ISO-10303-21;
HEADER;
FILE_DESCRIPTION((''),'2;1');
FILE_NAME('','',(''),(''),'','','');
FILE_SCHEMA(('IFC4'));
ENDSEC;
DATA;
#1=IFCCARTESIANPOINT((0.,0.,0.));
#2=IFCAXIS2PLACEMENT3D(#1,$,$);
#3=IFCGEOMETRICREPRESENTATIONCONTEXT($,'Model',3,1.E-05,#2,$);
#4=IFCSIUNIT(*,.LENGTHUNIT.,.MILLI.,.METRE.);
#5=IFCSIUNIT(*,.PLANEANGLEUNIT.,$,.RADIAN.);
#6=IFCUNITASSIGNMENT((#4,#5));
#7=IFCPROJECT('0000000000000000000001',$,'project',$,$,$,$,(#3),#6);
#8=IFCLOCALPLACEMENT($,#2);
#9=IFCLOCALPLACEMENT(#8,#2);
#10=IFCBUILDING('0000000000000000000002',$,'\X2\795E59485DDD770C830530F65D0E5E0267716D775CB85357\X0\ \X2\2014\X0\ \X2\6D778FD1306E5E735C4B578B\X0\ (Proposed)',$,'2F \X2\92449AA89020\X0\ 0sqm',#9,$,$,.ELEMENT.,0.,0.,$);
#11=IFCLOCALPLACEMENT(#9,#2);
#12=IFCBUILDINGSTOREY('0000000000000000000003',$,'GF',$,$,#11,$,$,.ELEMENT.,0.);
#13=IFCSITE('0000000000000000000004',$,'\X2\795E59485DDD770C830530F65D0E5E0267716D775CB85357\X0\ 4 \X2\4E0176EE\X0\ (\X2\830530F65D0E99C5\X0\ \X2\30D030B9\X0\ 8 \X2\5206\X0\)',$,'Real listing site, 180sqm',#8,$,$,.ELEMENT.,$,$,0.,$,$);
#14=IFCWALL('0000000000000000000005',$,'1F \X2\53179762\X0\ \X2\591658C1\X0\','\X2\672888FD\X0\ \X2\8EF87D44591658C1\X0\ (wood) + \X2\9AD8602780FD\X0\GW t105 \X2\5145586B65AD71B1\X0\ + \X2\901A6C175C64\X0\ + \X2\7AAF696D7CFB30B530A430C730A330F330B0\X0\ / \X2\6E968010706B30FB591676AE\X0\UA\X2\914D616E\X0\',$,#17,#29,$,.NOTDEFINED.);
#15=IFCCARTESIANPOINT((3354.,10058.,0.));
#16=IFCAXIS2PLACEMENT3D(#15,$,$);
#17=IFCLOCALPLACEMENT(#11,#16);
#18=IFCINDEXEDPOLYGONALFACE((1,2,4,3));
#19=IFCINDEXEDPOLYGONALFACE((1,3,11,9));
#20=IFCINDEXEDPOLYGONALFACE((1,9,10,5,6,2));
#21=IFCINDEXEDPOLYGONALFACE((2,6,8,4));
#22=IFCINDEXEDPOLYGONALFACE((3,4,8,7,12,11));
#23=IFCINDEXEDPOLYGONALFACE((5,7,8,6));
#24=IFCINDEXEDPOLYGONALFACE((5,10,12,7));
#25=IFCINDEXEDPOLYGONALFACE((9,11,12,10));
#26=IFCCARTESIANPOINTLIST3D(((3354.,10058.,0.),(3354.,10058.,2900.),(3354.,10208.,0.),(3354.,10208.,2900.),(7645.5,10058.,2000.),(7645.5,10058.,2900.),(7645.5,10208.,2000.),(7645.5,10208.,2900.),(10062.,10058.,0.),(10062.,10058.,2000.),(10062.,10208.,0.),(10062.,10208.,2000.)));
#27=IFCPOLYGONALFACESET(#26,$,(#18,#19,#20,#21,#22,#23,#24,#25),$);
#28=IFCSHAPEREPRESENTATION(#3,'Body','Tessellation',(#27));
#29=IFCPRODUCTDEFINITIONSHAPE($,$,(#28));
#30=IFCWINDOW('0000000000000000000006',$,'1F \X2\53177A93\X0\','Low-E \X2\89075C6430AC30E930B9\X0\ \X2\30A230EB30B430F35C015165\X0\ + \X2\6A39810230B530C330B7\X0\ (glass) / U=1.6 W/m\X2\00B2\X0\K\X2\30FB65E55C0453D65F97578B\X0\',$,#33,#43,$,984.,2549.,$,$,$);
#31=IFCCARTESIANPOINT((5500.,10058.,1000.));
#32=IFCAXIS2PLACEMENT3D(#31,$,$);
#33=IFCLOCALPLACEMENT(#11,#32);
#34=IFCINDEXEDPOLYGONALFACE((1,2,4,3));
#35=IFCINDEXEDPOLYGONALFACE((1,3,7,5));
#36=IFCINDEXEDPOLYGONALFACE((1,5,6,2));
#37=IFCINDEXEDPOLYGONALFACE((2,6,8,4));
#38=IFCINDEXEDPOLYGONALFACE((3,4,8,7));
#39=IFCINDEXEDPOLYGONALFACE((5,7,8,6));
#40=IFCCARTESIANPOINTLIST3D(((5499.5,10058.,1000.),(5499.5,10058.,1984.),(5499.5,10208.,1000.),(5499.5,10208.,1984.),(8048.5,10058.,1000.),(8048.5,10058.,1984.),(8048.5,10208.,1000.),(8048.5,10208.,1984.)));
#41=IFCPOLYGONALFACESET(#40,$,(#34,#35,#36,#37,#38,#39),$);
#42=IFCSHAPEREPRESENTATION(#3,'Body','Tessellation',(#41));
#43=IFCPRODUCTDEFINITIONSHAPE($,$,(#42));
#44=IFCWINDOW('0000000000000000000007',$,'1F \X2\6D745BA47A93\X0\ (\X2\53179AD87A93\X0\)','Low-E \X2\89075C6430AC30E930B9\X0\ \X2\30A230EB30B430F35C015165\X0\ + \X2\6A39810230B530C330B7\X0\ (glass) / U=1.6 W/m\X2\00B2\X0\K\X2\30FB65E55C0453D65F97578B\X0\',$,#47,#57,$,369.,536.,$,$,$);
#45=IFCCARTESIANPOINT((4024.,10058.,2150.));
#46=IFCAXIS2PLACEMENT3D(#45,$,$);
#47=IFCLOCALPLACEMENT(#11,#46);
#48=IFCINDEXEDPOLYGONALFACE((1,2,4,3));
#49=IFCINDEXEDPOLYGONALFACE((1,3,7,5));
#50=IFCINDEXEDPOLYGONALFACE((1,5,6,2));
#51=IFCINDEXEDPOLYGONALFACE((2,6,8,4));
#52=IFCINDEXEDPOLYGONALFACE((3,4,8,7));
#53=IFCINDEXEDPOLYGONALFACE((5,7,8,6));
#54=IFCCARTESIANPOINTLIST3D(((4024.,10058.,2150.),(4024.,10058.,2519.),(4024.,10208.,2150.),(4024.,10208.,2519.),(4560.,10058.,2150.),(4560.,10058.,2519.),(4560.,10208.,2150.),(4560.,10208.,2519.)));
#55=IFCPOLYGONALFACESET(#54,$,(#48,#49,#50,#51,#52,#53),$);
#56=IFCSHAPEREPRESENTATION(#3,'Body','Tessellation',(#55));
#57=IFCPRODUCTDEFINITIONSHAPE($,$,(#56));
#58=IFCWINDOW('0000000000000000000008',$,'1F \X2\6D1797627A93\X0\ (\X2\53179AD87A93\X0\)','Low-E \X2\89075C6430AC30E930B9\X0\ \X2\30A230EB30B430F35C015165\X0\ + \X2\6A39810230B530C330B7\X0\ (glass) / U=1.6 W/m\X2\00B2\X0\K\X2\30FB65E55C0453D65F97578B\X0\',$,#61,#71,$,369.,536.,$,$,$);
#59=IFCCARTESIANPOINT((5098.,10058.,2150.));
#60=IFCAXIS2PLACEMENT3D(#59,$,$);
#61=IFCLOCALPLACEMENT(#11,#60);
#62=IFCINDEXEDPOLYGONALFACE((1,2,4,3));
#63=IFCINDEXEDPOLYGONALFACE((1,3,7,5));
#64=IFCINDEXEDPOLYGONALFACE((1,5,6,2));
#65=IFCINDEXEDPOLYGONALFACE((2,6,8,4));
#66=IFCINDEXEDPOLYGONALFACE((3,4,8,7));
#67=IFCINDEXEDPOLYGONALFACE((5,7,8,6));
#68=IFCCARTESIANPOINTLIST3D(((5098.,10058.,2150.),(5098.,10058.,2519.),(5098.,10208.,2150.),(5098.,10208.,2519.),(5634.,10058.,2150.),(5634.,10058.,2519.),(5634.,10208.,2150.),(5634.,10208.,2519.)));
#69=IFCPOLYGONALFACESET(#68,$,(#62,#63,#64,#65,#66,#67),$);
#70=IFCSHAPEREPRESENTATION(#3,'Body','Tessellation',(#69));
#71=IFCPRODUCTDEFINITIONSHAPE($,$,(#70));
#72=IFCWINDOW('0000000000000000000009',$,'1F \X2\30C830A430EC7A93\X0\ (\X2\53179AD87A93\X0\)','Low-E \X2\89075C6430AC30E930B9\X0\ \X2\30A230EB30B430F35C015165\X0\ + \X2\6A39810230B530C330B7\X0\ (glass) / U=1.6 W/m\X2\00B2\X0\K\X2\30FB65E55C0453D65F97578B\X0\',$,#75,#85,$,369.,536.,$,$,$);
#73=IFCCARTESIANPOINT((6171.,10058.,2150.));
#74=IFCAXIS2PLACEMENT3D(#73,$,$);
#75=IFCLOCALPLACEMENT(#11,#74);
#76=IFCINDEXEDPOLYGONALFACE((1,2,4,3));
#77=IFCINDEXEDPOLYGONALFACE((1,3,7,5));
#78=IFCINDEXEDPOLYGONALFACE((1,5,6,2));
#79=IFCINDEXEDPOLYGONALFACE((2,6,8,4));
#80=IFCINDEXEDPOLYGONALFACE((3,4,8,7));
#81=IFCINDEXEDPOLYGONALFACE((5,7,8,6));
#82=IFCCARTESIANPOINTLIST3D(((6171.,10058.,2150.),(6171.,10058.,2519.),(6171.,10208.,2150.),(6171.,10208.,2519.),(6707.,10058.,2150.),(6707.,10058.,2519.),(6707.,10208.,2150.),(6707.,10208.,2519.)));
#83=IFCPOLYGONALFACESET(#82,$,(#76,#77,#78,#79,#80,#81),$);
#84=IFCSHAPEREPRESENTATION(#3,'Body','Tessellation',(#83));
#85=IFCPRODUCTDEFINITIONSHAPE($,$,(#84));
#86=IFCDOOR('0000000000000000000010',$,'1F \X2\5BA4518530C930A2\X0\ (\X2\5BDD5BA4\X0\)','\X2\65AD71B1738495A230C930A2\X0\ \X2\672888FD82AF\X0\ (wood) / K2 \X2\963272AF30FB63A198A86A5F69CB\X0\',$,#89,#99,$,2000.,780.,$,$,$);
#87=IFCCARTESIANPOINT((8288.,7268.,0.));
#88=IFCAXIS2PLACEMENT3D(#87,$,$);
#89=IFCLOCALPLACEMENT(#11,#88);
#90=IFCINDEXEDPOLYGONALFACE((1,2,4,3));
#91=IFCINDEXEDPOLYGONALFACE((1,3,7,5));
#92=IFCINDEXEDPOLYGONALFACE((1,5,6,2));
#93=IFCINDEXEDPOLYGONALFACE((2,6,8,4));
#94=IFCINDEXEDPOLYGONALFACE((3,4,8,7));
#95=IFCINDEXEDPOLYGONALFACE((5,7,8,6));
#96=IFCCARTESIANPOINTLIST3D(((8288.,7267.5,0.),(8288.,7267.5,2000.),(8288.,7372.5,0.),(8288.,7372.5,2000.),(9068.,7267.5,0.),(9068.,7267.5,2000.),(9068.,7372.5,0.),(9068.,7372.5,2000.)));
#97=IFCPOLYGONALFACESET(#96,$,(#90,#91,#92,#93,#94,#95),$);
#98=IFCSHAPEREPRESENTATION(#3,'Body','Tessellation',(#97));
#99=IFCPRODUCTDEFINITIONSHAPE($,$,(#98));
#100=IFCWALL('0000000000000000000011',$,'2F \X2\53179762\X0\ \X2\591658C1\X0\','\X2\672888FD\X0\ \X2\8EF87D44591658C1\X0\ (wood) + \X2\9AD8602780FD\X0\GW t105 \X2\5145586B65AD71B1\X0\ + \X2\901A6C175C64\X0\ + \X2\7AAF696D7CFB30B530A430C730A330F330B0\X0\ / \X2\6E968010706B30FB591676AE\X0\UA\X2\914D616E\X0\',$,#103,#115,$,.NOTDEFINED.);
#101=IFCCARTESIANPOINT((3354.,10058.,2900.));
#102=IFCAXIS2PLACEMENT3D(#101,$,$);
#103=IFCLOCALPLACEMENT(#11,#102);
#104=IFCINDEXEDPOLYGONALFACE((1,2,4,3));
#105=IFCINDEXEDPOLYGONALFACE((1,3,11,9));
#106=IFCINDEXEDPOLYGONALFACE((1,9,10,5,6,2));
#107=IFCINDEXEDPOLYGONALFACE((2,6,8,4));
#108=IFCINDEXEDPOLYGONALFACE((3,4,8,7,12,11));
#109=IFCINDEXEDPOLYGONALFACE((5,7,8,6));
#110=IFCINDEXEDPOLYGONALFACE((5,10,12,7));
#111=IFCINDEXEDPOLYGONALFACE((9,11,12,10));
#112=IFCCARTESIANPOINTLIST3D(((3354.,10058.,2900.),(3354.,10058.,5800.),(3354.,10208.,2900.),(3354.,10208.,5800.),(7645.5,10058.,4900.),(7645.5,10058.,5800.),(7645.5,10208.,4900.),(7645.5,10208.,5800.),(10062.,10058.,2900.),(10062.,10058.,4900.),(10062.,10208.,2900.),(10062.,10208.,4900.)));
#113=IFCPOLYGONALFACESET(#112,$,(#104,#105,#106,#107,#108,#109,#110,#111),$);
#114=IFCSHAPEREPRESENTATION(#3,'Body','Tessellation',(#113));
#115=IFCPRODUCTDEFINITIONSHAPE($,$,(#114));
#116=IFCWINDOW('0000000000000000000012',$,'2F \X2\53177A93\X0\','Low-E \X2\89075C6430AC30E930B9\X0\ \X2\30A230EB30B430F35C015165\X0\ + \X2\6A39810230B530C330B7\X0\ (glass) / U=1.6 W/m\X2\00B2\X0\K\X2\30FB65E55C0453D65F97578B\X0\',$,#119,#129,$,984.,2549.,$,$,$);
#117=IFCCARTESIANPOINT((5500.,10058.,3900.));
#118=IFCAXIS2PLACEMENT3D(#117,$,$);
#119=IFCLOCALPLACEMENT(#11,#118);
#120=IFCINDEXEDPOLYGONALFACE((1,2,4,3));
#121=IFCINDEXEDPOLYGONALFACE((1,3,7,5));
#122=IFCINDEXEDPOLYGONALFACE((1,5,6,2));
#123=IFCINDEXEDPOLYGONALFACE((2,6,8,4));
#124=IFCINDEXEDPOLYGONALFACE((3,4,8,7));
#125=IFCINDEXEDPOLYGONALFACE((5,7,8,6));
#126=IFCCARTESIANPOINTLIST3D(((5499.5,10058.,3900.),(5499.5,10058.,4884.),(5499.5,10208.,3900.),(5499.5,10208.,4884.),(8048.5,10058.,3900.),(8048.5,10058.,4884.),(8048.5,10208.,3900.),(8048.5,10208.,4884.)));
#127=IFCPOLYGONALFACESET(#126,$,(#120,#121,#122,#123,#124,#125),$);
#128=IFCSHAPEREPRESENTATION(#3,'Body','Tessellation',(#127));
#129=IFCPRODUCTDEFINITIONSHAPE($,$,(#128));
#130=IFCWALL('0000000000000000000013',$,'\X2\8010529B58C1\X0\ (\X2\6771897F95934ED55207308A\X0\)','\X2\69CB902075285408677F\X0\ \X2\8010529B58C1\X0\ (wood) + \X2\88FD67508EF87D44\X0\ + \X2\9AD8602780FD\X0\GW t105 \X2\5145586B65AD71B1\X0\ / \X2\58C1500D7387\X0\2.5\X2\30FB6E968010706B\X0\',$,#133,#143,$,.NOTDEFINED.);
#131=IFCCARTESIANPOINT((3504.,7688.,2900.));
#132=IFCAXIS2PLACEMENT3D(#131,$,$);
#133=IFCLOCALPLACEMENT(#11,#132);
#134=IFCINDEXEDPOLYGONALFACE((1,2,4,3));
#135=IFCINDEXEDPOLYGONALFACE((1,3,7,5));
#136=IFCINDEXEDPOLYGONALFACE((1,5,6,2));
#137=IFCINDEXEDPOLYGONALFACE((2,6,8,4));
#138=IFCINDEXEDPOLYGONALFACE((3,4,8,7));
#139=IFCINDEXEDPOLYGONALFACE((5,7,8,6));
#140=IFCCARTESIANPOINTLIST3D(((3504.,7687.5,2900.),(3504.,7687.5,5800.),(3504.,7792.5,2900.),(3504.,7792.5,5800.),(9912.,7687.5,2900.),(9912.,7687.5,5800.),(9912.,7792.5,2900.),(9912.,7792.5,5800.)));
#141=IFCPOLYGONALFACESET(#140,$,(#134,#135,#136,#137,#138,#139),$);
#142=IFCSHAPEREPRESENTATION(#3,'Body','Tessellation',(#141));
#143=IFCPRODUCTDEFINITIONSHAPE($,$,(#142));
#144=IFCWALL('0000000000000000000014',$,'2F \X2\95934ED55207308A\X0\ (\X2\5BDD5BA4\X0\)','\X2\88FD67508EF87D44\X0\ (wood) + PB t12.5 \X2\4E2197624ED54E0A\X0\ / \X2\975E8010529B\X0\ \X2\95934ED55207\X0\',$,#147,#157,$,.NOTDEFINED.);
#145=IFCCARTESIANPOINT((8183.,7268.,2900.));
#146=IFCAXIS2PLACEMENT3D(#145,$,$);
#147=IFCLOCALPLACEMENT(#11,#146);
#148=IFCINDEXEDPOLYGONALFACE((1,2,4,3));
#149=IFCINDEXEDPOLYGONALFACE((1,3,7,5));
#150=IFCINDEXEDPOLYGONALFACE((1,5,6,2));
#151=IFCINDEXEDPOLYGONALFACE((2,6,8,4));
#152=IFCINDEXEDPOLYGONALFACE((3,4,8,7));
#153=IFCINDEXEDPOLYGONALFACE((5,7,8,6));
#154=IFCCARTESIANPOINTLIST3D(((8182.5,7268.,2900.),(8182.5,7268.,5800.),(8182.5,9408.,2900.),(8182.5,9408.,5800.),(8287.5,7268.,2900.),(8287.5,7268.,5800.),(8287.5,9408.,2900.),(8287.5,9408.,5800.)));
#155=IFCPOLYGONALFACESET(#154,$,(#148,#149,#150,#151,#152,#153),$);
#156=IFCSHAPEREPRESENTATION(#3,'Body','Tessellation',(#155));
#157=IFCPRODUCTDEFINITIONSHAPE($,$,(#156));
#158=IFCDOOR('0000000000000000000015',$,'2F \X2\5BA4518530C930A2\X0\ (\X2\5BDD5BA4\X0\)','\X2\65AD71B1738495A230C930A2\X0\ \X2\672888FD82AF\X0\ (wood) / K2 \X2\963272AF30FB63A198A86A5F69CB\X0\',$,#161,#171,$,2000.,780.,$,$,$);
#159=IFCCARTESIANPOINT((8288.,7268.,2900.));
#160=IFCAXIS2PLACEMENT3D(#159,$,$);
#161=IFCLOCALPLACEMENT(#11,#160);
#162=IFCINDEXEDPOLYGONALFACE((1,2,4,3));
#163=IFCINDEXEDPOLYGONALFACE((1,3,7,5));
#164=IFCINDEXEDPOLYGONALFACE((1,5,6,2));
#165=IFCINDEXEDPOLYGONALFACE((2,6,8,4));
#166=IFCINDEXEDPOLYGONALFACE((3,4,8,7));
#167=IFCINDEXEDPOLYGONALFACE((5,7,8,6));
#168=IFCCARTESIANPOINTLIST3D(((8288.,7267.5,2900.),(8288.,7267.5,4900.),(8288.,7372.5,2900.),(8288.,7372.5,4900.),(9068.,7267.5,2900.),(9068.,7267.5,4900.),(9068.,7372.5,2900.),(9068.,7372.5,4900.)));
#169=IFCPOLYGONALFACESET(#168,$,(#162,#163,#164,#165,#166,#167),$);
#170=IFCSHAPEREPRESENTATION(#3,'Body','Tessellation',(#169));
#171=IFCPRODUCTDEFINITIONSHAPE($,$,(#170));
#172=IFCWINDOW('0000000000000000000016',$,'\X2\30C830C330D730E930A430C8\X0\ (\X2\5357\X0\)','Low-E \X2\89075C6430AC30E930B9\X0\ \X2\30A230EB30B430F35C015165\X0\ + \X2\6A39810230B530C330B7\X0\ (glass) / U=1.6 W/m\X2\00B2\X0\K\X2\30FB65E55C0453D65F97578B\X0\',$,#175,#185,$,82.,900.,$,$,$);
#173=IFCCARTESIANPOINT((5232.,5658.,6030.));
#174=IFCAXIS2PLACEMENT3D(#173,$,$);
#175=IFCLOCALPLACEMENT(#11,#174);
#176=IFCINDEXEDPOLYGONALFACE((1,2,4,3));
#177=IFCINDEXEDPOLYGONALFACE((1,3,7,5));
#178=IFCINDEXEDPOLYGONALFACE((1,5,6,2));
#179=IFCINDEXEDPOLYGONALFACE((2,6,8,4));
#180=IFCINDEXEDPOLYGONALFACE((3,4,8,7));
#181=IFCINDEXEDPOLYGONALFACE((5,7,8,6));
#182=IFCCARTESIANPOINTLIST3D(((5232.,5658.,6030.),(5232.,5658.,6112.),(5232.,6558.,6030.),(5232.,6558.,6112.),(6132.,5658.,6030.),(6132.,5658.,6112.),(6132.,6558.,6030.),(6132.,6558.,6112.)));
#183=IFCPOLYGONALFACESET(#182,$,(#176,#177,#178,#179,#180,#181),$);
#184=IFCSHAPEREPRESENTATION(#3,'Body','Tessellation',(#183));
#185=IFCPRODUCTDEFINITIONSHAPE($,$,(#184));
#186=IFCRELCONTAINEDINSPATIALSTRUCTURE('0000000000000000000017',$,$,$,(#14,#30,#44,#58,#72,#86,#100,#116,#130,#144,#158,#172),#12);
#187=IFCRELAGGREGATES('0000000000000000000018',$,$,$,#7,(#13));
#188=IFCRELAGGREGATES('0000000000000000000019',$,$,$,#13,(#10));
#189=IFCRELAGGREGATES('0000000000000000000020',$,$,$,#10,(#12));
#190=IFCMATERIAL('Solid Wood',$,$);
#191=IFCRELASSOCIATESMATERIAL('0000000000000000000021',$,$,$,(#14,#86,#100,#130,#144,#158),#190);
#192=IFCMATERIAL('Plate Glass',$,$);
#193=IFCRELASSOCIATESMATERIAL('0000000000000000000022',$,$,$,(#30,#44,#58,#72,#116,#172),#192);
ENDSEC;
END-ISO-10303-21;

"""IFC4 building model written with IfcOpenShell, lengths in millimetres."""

from ifc_helpers import new_model, si_unit, frame, frame_2d, origin, place, context, project, spatial, rectangle, extrude, material, element, fill, save


model = new_model("IFC4")

# Units and contexts
model_context = context("Model", 3, precision=1e-05, world=origin())
ifc_project = project(units=[si_unit("LENGTHUNIT", "METRE", prefix="MILLI"), si_unit("PLANEANGLEUNIT", "RADIAN")], contexts=[model_context])

# Site, building, storey
site_placement = place(None, origin())
site = spatial("IfcSite", under=ifc_project, at=site_placement, Name="神奈川県茅ヶ崎市東海岸南 4 丁目 (茅ヶ崎駅 バス 8 分)", ObjectType="Real listing site, 180sqm", CompositionType="ELEMENT", RefElevation=0.0)
building_placement = place(site_placement, origin())
building = spatial("IfcBuilding", under=site, at=building_placement, Name="神奈川県茅ヶ崎市東海岸南 — 海近の平屋型 (Proposed)", ObjectType="2F 鉄骨造 0sqm", CompositionType="ELEMENT", ElevationOfRefHeight=0.0, ElevationOfTerrain=0.0)
storey_placement = place(building_placement, origin())
storey = spatial("IfcBuildingStorey", under=building, at=storey_placement, Name="GF", CompositionType="ELEMENT", Elevation=0.0)

# Wall, openings, windows
ifc_material_1 = material(Name="Solid Wood")
wall_1_placement = place(storey_placement, frame((3354.0, 10058.0, 0.0)))
wall_1 = element("IfcWall", 1, at=wall_1_placement, inside=storey, material=ifc_material_1, Name="1F 北面 外壁", Description="木製 軸組外壁 (wood) + 高性能GW t105 充填断熱 + 通気層 + 窯業系サイディング / 準耐火・外皮UA配慮", PredefinedType="NOTDEFINED", context=model_context, shape_type="SweptSolid", body=[
    extrude(rectangle(XDim=6708.0, YDim=150.0, at=frame_2d((3354.0, 75.0))), frame((3354.0, 10058.0, 0.0)), (0.0, 0.0, 1.0), 2900.0),
])
opening_1_placement = place(storey_placement, frame((5500.0, 10058.0, 1000.0)))
opening_1 = element("IfcOpeningElement", 2, at=opening_1_placement, cuts=wall_1, PredefinedType="NOTDEFINED", context=model_context, shape_type="SweptSolid", body=[
    extrude(rectangle(XDim=2549.0, YDim=150.0, at=frame_2d((1274.0, 75.0))), frame((5500.0, 10058.0, 1000.0)), (0.0, 0.0, 1.0), 984.0),
])
opening_2_placement = place(storey_placement, frame((4024.0, 10058.0, 2150.0)))
opening_2 = element("IfcOpeningElement", 3, at=opening_2_placement, cuts=wall_1, PredefinedType="NOTDEFINED", context=model_context, shape_type="SweptSolid", body=[
    extrude(rectangle(XDim=536.0, YDim=150.0, at=frame_2d((268.0, 75.0))), frame((4024.0, 10058.0, 2150.0)), (0.0, 0.0, 1.0), 369.0),
])
opening_3_placement = place(storey_placement, frame((5098.0, 10058.0, 2150.0)))
opening_3 = element("IfcOpeningElement", 4, at=opening_3_placement, cuts=wall_1, PredefinedType="NOTDEFINED", context=model_context, shape_type="SweptSolid", body=[
    extrude(rectangle(XDim=536.0, YDim=150.0, at=frame_2d((268.0, 75.0))), frame((5098.0, 10058.0, 2150.0)), (0.0, 0.0, 1.0), 369.0),
])
opening_4_placement = place(storey_placement, frame((6171.0, 10058.0, 2150.0)))
opening_4 = element("IfcOpeningElement", 5, at=opening_4_placement, cuts=wall_1, PredefinedType="NOTDEFINED", context=model_context, shape_type="SweptSolid", body=[
    extrude(rectangle(XDim=536.0, YDim=150.0, at=frame_2d((268.0, 75.0))), frame((6171.0, 10058.0, 2150.0)), (0.0, 0.0, 1.0), 369.0),
])
ifc_material_2 = material(Name="Plate Glass")
window_1_placement = place(storey_placement, frame((5500.0, 10058.0, 1000.0)))
window_1 = element("IfcWindow", 6, at=window_1_placement, inside=storey, material=ifc_material_2, Name="1F 北窓", Description="Low-E 複層ガラス アルゴン封入 + 樹脂サッシ (glass) / U=1.6 W/m²K・日射取得型", OverallHeight=984.0, OverallWidth=2549.0, context=model_context, shape_type="SweptSolid", body=[
    extrude(rectangle(XDim=2549.0, YDim=150.0, at=frame_2d((1274.0, 75.0))), frame((5500.0, 10058.0, 1000.0)), (0.0, 0.0, 1.0), 984.0),
])
fill(opening_1, window_1)
window_2_placement = place(storey_placement, frame((4024.0, 10058.0, 2150.0)))
window_2 = element("IfcWindow", 7, at=window_2_placement, inside=storey, material=ifc_material_2, Name="1F 浴室窓 (北高窓)", Description="Low-E 複層ガラス アルゴン封入 + 樹脂サッシ (glass) / U=1.6 W/m²K・日射取得型", OverallHeight=369.0, OverallWidth=536.0, context=model_context, shape_type="SweptSolid", body=[
    extrude(rectangle(XDim=536.0, YDim=150.0, at=frame_2d((268.0, 75.0))), frame((4024.0, 10058.0, 2150.0)), (0.0, 0.0, 1.0), 369.0),
])
fill(opening_2, window_2)
window_3_placement = place(storey_placement, frame((5098.0, 10058.0, 2150.0)))
window_3 = element("IfcWindow", 8, at=window_3_placement, inside=storey, material=ifc_material_2, Name="1F 洗面窓 (北高窓)", Description="Low-E 複層ガラス アルゴン封入 + 樹脂サッシ (glass) / U=1.6 W/m²K・日射取得型", OverallHeight=369.0, OverallWidth=536.0, context=model_context, shape_type="SweptSolid", body=[
    extrude(rectangle(XDim=536.0, YDim=150.0, at=frame_2d((268.0, 75.0))), frame((5098.0, 10058.0, 2150.0)), (0.0, 0.0, 1.0), 369.0),
])
fill(opening_3, window_3)
window_4_placement = place(storey_placement, frame((6171.0, 10058.0, 2150.0)))
window_4 = element("IfcWindow", 9, at=window_4_placement, inside=storey, material=ifc_material_2, Name="1F トイレ窓 (北高窓)", Description="Low-E 複層ガラス アルゴン封入 + 樹脂サッシ (glass) / U=1.6 W/m²K・日射取得型", OverallHeight=369.0, OverallWidth=536.0, context=model_context, shape_type="SweptSolid", body=[
    extrude(rectangle(XDim=536.0, YDim=150.0, at=frame_2d((268.0, 75.0))), frame((6171.0, 10058.0, 2150.0)), (0.0, 0.0, 1.0), 369.0),
])
fill(opening_4, window_4)

# Door
door_1_placement = place(storey_placement, frame((8288.0, 7268.0, 0.0)))
element("IfcDoor", 10, at=door_1_placement, inside=storey, material=ifc_material_1, Name="1F 室内ドア (寝室)", Description="断熱玄関ドア 木製芯 (wood) / K2 防犯・採風機構", OverallHeight=2000.0, OverallWidth=780.0, context=model_context, shape_type="SweptSolid", body=[
    extrude(rectangle(XDim=780.0, YDim=105.0, at=frame_2d((390.0, 52.0))), frame((8288.0, 7268.0, 0.0)), (0.0, 0.0, 1.0), 2000.0),
])

# Wall, opening, window
wall_2_placement = place(storey_placement, frame((3354.0, 10058.0, 2900.0)))
wall_2 = element("IfcWall", 11, at=wall_2_placement, inside=storey, material=ifc_material_1, Name="2F 北面 外壁", Description="木製 軸組外壁 (wood) + 高性能GW t105 充填断熱 + 通気層 + 窯業系サイディング / 準耐火・外皮UA配慮", PredefinedType="NOTDEFINED", context=model_context, shape_type="SweptSolid", body=[
    extrude(rectangle(XDim=6708.0, YDim=150.0, at=frame_2d((3354.0, 75.0))), frame((3354.0, 10058.0, 2900.0)), (0.0, 0.0, 1.0), 2900.0),
])
opening_5_placement = place(storey_placement, frame((5500.0, 10058.0, 3900.0)))
opening_5 = element("IfcOpeningElement", 12, at=opening_5_placement, cuts=wall_2, PredefinedType="NOTDEFINED", context=model_context, shape_type="SweptSolid", body=[
    extrude(rectangle(XDim=2549.0, YDim=150.0, at=frame_2d((1274.0, 75.0))), frame((5500.0, 10058.0, 3900.0)), (0.0, 0.0, 1.0), 984.0),
])
window_5_placement = place(storey_placement, frame((5500.0, 10058.0, 3900.0)))
window_5 = element("IfcWindow", 13, at=window_5_placement, inside=storey, material=ifc_material_2, Name="2F 北窓", Description="Low-E 複層ガラス アルゴン封入 + 樹脂サッシ (glass) / U=1.6 W/m²K・日射取得型", OverallHeight=984.0, OverallWidth=2549.0, context=model_context, shape_type="SweptSolid", body=[
    extrude(rectangle(XDim=2549.0, YDim=150.0, at=frame_2d((1274.0, 75.0))), frame((5500.0, 10058.0, 3900.0)), (0.0, 0.0, 1.0), 984.0),
])
fill(opening_5, window_5)

# Walls
wall_3_placement = place(storey_placement, frame((3504.0, 7688.0, 2900.0)))
element("IfcWall", 14, at=wall_3_placement, inside=storey, material=ifc_material_1, Name="耐力壁 (東西間仕切り)", Description="構造用合板 耐力壁 (wood) + 製材軸組 + 高性能GW t105 充填断熱 / 壁倍率2.5・準耐火", PredefinedType="NOTDEFINED", context=model_context, shape_type="SweptSolid", body=[
    extrude(rectangle(XDim=6408.0, YDim=105.0, at=frame_2d((3204.0, 52.0))), frame((3504.0, 7688.0, 2900.0)), (0.0, 0.0, 1.0), 2900.0),
])
wall_4_placement = place(storey_placement, frame((8183.0, 7268.0, 2900.0)))
element("IfcWall", 15, at=wall_4_placement, inside=storey, material=ifc_material_1, Name="2F 間仕切り (寝室)", Description="製材軸組 (wood) + PB t12.5 両面仕上 / 非耐力 間仕切", PredefinedType="NOTDEFINED", context=model_context, shape_type="SweptSolid", body=[
    extrude(rectangle(XDim=105.0, YDim=2140.0, at=frame_2d((52.0, 1070.0))), frame((8183.0, 7268.0, 2900.0)), (0.0, 0.0, 1.0), 2900.0),
])

# Door
door_2_placement = place(storey_placement, frame((8288.0, 7268.0, 2900.0)))
element("IfcDoor", 16, at=door_2_placement, inside=storey, material=ifc_material_1, Name="2F 室内ドア (寝室)", Description="断熱玄関ドア 木製芯 (wood) / K2 防犯・採風機構", OverallHeight=2000.0, OverallWidth=780.0, context=model_context, shape_type="SweptSolid", body=[
    extrude(rectangle(XDim=780.0, YDim=105.0, at=frame_2d((390.0, 52.0))), frame((8288.0, 7268.0, 2900.0)), (0.0, 0.0, 1.0), 2000.0),
])

# Window
window_6_placement = place(storey_placement, frame((5232.0, 5658.0, 6030.0)))
element("IfcWindow", 17, at=window_6_placement, inside=storey, material=ifc_material_2, Name="トップライト (南)", Description="Low-E 複層ガラス アルゴン封入 + 樹脂サッシ (glass) / U=1.6 W/m²K・日射取得型", OverallHeight=82.0, OverallWidth=900.0, context=model_context, shape_type="SweptSolid", body=[
    extrude(rectangle(XDim=900.0, YDim=900.0, at=frame_2d((450.0, 450.0))), frame((5232.0, 5658.0, 6030.0)), (0.0, 0.0, 1.0), 82.0),
])

save(model, "model.ifc")
